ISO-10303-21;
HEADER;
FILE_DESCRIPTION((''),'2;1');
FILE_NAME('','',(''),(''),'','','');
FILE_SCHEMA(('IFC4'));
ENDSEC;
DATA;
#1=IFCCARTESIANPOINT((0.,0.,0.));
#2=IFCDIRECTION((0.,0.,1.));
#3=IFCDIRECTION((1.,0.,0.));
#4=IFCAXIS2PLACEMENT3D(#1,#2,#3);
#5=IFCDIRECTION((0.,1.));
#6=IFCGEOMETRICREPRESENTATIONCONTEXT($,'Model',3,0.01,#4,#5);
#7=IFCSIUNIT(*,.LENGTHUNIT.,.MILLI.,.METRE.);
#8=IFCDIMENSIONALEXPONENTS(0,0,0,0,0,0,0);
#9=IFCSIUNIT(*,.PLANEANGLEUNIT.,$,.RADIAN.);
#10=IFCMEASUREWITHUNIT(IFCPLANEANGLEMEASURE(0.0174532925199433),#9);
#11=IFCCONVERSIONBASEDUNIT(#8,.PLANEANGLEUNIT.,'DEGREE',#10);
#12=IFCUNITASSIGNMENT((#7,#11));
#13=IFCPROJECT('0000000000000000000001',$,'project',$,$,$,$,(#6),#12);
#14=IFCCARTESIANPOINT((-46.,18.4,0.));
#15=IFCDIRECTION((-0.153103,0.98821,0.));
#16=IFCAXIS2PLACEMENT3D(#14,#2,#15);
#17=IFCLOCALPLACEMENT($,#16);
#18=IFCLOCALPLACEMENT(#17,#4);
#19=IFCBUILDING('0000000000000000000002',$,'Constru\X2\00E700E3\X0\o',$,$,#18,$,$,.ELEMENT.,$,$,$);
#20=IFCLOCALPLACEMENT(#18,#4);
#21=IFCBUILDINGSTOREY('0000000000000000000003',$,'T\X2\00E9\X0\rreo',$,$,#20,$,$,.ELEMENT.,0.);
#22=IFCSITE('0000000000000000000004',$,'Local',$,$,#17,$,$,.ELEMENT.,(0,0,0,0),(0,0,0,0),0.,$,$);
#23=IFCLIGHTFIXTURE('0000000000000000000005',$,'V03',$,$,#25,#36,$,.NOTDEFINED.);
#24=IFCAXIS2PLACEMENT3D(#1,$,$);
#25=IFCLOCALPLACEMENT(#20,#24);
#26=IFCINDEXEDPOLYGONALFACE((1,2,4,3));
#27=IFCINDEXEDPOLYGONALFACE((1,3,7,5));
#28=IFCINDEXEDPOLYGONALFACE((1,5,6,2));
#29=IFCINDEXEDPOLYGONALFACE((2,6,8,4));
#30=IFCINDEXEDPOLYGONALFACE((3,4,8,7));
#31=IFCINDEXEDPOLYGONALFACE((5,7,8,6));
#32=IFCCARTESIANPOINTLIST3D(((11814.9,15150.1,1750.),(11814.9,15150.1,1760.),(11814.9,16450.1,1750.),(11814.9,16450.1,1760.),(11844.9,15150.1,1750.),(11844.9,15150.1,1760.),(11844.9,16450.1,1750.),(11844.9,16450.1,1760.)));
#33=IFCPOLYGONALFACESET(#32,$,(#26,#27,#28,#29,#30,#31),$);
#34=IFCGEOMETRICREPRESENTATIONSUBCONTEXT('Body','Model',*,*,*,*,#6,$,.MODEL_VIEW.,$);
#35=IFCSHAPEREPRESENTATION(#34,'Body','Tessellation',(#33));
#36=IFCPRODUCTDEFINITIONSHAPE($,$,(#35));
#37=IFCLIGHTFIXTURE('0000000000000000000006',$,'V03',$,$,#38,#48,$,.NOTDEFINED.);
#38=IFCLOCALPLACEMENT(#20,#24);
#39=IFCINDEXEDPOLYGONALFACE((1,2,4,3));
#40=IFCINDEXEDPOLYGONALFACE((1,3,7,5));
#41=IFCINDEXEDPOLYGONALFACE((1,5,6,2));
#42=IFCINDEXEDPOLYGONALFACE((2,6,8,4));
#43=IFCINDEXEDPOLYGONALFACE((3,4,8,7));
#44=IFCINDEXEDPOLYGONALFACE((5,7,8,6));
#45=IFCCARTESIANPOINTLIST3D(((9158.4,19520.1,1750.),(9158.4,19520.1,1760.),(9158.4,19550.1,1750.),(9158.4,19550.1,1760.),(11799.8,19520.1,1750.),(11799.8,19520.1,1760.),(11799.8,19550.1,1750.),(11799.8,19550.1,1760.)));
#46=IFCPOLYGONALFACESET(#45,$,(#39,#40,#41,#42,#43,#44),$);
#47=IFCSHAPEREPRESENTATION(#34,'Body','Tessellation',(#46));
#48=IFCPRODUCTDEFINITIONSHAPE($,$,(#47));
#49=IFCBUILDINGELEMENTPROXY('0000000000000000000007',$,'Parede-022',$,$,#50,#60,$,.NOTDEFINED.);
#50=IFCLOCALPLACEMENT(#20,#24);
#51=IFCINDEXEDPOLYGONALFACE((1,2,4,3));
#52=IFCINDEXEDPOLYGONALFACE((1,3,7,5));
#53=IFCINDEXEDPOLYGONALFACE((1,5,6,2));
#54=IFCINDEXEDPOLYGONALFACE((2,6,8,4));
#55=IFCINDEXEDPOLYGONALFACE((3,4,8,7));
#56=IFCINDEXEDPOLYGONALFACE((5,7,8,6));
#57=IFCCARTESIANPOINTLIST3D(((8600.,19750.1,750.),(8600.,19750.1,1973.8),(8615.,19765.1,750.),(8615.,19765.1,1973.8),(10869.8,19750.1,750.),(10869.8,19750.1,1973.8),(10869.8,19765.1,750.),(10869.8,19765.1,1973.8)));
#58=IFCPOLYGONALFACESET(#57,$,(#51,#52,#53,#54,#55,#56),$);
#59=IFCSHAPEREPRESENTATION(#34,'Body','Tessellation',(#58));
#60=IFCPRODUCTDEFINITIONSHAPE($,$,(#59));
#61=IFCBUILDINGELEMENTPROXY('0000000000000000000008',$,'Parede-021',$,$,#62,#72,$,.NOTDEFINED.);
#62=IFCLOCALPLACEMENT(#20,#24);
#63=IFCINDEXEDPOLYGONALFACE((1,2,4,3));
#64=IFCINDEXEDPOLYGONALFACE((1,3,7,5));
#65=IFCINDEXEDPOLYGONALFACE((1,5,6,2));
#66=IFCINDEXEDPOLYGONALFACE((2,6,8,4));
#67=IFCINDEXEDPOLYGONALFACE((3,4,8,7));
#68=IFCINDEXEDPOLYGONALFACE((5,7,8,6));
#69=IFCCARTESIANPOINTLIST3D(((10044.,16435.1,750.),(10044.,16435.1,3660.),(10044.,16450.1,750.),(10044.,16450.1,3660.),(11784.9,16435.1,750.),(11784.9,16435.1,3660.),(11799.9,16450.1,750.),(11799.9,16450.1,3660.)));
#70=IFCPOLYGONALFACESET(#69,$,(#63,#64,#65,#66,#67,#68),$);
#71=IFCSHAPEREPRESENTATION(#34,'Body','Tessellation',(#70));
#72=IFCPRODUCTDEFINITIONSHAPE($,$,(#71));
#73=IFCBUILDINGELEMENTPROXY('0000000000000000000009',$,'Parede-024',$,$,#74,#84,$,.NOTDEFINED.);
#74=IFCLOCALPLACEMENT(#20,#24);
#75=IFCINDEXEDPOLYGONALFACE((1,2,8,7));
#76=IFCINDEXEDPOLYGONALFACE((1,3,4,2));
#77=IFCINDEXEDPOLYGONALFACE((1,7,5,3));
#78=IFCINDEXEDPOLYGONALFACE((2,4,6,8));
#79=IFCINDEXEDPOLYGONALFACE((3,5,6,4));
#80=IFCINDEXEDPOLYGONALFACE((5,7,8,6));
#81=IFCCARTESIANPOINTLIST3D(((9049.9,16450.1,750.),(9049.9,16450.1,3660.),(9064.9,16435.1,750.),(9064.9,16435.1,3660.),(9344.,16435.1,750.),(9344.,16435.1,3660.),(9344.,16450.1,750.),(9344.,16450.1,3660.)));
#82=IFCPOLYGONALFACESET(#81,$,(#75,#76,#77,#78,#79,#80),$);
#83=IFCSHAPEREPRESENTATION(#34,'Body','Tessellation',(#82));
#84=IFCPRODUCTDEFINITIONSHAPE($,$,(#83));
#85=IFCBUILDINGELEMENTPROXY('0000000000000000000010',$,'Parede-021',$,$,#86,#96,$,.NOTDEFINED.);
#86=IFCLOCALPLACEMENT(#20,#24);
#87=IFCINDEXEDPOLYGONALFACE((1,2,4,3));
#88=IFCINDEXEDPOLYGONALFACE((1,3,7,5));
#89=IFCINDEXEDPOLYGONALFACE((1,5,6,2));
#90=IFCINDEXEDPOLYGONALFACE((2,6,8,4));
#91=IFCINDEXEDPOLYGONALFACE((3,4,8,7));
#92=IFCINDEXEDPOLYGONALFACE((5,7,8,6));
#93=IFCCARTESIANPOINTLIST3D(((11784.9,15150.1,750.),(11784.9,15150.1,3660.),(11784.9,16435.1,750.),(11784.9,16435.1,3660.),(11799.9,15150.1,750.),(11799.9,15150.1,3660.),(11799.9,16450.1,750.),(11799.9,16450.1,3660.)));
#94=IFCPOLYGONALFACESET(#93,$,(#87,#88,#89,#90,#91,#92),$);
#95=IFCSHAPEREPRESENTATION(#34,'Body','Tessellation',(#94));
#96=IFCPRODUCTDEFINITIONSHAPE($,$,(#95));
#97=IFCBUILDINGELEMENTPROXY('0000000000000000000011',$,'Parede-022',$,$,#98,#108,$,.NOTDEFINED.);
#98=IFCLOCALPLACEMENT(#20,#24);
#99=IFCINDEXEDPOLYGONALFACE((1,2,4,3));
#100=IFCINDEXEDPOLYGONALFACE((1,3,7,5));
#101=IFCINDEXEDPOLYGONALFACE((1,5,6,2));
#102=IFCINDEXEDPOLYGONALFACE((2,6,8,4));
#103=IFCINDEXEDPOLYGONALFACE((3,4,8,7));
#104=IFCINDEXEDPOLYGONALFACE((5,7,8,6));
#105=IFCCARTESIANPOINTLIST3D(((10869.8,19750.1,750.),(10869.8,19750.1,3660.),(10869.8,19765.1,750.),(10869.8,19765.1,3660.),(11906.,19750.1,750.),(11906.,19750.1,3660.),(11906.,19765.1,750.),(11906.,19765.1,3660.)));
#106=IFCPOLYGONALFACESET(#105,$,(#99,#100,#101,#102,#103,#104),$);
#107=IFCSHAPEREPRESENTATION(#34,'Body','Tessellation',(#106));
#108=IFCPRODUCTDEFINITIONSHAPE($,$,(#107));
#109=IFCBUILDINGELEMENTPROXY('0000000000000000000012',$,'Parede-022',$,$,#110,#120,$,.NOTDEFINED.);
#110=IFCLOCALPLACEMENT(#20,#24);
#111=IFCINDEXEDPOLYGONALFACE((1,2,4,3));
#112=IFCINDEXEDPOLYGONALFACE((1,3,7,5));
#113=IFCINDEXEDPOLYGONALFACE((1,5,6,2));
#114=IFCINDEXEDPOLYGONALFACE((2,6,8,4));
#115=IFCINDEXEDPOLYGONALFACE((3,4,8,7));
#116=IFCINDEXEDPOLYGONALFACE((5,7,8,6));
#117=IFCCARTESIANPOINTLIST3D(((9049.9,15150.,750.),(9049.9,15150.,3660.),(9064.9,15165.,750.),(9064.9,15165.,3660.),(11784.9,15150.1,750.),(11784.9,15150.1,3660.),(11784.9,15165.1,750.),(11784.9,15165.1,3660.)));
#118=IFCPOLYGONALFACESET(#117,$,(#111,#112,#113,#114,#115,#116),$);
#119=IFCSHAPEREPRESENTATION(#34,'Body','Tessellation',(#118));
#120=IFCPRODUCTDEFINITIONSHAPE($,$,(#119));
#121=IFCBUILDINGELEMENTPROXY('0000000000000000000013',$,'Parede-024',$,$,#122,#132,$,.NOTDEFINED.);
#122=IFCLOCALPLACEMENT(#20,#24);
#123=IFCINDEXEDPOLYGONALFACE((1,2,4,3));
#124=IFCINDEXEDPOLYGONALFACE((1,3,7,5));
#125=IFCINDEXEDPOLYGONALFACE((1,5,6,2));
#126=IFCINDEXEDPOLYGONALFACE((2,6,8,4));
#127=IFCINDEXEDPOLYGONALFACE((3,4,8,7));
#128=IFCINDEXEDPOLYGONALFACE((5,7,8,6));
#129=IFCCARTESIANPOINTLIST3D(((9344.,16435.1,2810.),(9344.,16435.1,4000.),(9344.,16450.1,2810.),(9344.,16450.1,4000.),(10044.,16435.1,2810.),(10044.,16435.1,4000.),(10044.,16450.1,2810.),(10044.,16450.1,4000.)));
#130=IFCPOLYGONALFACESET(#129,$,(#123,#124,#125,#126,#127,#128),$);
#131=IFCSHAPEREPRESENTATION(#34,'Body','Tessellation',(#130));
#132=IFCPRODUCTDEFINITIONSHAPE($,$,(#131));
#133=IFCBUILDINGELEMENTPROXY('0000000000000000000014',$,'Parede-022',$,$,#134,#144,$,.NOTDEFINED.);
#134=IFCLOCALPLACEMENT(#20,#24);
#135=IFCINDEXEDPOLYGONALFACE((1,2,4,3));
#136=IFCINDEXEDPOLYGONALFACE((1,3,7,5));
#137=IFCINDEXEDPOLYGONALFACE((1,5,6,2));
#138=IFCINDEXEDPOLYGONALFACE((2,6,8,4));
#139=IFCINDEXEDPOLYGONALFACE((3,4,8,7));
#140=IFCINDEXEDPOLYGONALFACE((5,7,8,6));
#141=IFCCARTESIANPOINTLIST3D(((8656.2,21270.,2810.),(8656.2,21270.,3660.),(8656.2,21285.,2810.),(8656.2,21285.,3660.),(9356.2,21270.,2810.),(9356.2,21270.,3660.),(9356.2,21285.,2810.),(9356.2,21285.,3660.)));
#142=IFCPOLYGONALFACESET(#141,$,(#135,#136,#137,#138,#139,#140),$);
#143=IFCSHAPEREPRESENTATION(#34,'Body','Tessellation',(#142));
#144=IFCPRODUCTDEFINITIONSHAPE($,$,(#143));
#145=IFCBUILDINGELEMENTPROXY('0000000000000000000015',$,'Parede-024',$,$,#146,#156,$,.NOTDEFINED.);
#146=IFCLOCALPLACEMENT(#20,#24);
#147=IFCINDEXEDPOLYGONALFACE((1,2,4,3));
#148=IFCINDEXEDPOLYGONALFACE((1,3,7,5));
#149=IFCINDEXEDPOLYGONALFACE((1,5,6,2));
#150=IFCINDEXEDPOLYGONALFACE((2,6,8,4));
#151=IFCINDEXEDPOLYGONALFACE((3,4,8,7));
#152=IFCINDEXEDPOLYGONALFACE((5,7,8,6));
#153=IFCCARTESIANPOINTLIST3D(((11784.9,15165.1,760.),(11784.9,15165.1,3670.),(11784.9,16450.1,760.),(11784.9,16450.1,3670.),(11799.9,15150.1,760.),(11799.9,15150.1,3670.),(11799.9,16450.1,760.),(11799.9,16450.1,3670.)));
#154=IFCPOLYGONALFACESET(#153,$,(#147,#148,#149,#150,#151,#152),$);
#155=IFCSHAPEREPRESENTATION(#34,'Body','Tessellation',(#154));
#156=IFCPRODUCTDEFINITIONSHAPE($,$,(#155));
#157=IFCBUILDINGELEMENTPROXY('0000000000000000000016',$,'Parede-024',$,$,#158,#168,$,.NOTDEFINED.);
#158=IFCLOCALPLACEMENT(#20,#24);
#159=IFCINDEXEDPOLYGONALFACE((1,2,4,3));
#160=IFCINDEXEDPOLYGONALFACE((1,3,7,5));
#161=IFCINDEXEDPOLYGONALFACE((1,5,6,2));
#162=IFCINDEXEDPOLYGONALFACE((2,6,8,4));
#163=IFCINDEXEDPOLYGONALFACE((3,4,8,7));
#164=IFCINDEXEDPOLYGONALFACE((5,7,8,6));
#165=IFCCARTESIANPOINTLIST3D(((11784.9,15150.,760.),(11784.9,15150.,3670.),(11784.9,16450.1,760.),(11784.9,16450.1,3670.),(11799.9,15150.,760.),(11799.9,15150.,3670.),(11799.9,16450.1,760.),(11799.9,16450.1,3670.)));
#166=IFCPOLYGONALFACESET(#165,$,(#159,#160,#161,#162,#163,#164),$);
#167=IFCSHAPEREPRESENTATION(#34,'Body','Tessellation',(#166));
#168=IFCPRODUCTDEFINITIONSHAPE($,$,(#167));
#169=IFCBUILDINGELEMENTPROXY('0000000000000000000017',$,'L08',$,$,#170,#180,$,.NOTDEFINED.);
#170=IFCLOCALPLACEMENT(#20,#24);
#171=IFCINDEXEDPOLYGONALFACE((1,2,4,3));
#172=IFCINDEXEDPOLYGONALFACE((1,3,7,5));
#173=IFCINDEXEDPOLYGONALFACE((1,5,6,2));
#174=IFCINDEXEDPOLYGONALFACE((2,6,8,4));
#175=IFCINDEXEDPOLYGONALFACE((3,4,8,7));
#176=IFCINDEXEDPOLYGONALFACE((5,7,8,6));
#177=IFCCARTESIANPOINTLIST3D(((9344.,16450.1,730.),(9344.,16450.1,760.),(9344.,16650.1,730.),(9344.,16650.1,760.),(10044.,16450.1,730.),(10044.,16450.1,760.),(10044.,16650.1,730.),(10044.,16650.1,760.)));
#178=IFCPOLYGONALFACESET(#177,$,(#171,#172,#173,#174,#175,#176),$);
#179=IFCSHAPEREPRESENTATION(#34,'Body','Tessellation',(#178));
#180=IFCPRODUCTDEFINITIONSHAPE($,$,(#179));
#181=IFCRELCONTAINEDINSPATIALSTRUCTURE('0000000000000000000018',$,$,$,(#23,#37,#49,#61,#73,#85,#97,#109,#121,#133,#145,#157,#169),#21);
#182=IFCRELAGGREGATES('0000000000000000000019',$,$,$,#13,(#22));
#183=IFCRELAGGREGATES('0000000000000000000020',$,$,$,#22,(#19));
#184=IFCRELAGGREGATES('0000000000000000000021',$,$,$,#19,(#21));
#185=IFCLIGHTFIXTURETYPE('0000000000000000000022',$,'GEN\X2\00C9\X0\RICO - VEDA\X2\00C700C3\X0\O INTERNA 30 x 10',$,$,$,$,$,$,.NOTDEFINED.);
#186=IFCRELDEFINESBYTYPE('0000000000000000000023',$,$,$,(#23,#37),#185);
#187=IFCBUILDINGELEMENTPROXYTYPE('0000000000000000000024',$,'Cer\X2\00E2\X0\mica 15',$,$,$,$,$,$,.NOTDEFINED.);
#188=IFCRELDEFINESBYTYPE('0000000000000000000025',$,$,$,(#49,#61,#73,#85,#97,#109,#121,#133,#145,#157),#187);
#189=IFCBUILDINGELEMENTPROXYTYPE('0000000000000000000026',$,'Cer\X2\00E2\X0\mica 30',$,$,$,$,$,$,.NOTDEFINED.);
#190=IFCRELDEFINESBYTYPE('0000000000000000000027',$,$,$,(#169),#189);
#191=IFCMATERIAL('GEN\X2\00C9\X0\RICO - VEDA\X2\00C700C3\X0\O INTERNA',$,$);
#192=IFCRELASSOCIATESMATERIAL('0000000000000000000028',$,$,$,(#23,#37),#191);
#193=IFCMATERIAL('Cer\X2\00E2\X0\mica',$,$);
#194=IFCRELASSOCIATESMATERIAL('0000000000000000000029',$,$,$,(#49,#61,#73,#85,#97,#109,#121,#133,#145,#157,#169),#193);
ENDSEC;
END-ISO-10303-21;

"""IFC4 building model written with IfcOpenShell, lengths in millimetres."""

from ifc_helpers import new_model, entity, si_unit, converted_unit, direction, frame, frame_2d, origin_with_axes, place, context, subcontext, project, spatial, line, indexed_curve, rectangle, outline, extrude, material, type_object, element, save


model = new_model("IFC4")

# Units and contexts
model_context = context("Model", 3, precision=0.01, world=origin_with_axes(), true_north=direction((0.0, 1.0)))
body_context = subcontext(model_context, "Body", "Model", "MODEL_VIEW")
ifc_project = project(units=[si_unit("LENGTHUNIT", "METRE", prefix="MILLI"), converted_unit("PLANEANGLEUNIT", "DEGREE", entity("IfcPlaneAngleMeasure", 0.0174532925199433), si_unit("PLANEANGLEUNIT", "RADIAN"), dimensions=[0, 0, 0, 0, 0, 0, 0])], contexts=[model_context])

# Site, building, storey
site_placement = place(None, frame((-46.0, 18.4, 0.0), z_axis=(0.0, 0.0, 1.0), x_axis=(-0.153103, 0.98821, 0.0)))
site = spatial("IfcSite", under=ifc_project, at=site_placement, Name="Local", CompositionType="ELEMENT", RefLatitude=(0, 0, 0, 0), RefLongitude=(0, 0, 0, 0), RefElevation=0.0)
building_placement = place(site_placement, origin_with_axes())
building = spatial("IfcBuilding", under=site, at=building_placement, Name="Construção", CompositionType="ELEMENT")
storey_placement = place(building_placement, origin_with_axes())
storey = spatial("IfcBuildingStorey", under=building, at=storey_placement, Name="Térreo", CompositionType="ELEMENT", Elevation=0.0)

# Shared definitions
ifc_material_1 = material(Name="GENÉRICO - VEDAÇÃO INTERNA")

# Light fixtures
light_fixture_type = type_object("IfcLightFixtureType", Name="GENÉRICO - VEDAÇÃO INTERNA 30 x 10", PredefinedType="NOTDEFINED")
light_fixture_1_placement = place(storey_placement, frame((11844.9, 15150.1, 1760.0), z_axis=(0.0, 0.0, 1.0), x_axis=(1.0, 0.000019, 0.0)))
element("IfcLightFixture", 1, at=light_fixture_1_placement, inside=storey, type_object=light_fixture_type, material=ifc_material_1, Name="V03", PredefinedType="NOTDEFINED", context=body_context, shape_type="SweptSolid", body=[
    extrude(rectangle(XDim=10.0, YDim=30.0, at=frame_2d((-5.0, -15.0), x_axis=(1.0, 0.0))), frame((0.0, 0.0, 0.0), z_axis=(0.0, 1.0, 0.0), x_axis=(0.0, 0.0, 1.0)), (0.0, 0.0, 1.0), 1300.0),
])
light_fixture_2_placement = place(storey_placement, frame((9158.4, 19520.1, 1760.0), z_axis=(0.0, 0.0, 1.0), x_axis=(0.0, -1.0, 0.0)))
element("IfcLightFixture", 2, at=light_fixture_2_placement, inside=storey, type_object=light_fixture_type, material=ifc_material_1, Name="V03", PredefinedType="NOTDEFINED", context=body_context, shape_type="SweptSolid", body=[
    extrude(rectangle(XDim=10.0, YDim=30.0, at=frame_2d((-5.0, -15.0), x_axis=(1.0, 0.0))), frame((0.0, 0.0, 0.0), z_axis=(0.0, 1.0, 0.0), x_axis=(0.0, 0.0, 1.0)), (0.0, 0.0, 1.0), 2641.4),
])

# Building element proxies
ifc_material_2 = material(Name="Cerâmica")
building_element_proxy_type_1 = type_object("IfcBuildingElementProxyType", Name="Cerâmica 15", PredefinedType="NOTDEFINED")
proxy_1_placement = place(storey_placement, frame((10869.8, 19750.1, 750.0), z_axis=(0.0, 0.0, 1.0), x_axis=(-1.0, 0.0, 0.0)))
element("IfcBuildingElementProxy", 3, at=proxy_1_placement, inside=storey, type_object=building_element_proxy_type_1, material=ifc_material_2, Name="Parede-022", PredefinedType="NOTDEFINED", context=body_context, shape_type="SweptSolid", body=[
    extrude(outline(indexed_curve([(0.0, -15.0), (2254.9, -15.0), (2269.9, 0.0), (0.0, 0.0)], segments=[line(1, 2, 3, 4, 1)])), origin_with_axes(), (0.0, 0.0, 1.0), 1223.8),
])
proxy_2_placement = place(storey_placement, frame((11799.9, 16450.1, 750.0), z_axis=(0.0, 0.0, 1.0), x_axis=(-1.0, 0.0, 0.0)))
element("IfcBuildingElementProxy", 4, at=proxy_2_placement, inside=storey, type_object=building_element_proxy_type_1, material=ifc_material_2, Name="Parede-021", PredefinedType="NOTDEFINED", context=body_context, shape_type="SweptSolid", body=[
    extrude(outline(indexed_curve([(0.0, 0.0), (1755.9, 0.0), (1755.9, 15.0), (15.0, 15.0)], segments=[line(1, 2, 3, 4, 1)])), origin_with_axes(), (0.0, 0.0, 1.0), 2910.0),
])
proxy_3_placement = place(storey_placement, frame((9049.9, 16450.1, 750.0), z_axis=(0.0, 0.0, 1.0), x_axis=(1.0, 0.0, 0.0)))
element("IfcBuildingElementProxy", 5, at=proxy_3_placement, inside=storey, type_object=building_element_proxy_type_1, material=ifc_material_2, Name="Parede-024", PredefinedType="NOTDEFINED", context=body_context, shape_type="SweptSolid", body=[
    extrude(outline(indexed_curve([(15.0, -15.0), (294.0, -15.0), (294.0, 0.0), (0.0, 0.0)], segments=[line(1, 2, 3, 4, 1)])), origin_with_axes(), (0.0, 0.0, 1.0), 2910.0),
])
proxy_4_placement = place(storey_placement, frame((11799.9, 16450.1, 750.0), z_axis=(0.0, 0.0, 1.0), x_axis=(0.000019, -1.0, 0.0)))
element("IfcBuildingElementProxy", 6, at=proxy_4_placement, inside=storey, type_object=building_element_proxy_type_1, material=ifc_material_2, Name="Parede-021", PredefinedType="NOTDEFINED", context=body_context, shape_type="SweptSolid", body=[
    extrude(outline(indexed_curve([(15.0, -15.0), (1300.0, -15.0), (1300.0, 0.0), (0.0, 0.0)], segments=[line(1, 2, 3, 4, 1)])), origin_with_axes(), (0.0, 0.0, 1.0), 2910.0),
])
proxy_5_placement = place(storey_placement, frame((11906.0, 19750.1, 750.0), z_axis=(0.0, 0.0, 1.0), x_axis=(-1.0, 0.0, 0.0)))
element("IfcBuildingElementProxy", 7, at=proxy_5_placement, inside=storey, type_object=building_element_proxy_type_1, material=ifc_material_2, Name="Parede-022", PredefinedType="NOTDEFINED", context=body_context, shape_type="SweptSolid", body=[
    extrude(outline(indexed_curve([(0.0, -15.0), (1036.2, -15.0), (1036.2, 0.0), (0.0, 0.0)], segments=[line(1, 2, 3, 4, 1)])), origin_with_axes(), (0.0, 0.0, 1.0), 2910.0),
])
proxy_6_placement = place(storey_placement, frame((11799.9, 15150.1, 750.0), z_axis=(0.0, 0.0, 1.0), x_axis=(-1.0, -0.000036, 0.0)))
element("IfcBuildingElementProxy", 8, at=proxy_6_placement, inside=storey, type_object=building_element_proxy_type_1, material=ifc_material_2, Name="Parede-022", PredefinedType="NOTDEFINED", context=body_context, shape_type="SweptSolid", body=[
    extrude(outline(indexed_curve([(15.0, -15.0), (2734.9, -15.0), (2750.0, 0.0), (15.0, 0.0)], segments=[line(1, 2, 3, 4, 1)])), origin_with_axes(), (0.0, 0.0, 1.0), 2910.0),
])
proxy_7_placement = place(storey_placement, frame((9344.0, 16450.1, 2810.0), z_axis=(0.0, 0.0, 1.0), x_axis=(1.0, 0.0, 0.0)))
element("IfcBuildingElementProxy", 9, at=proxy_7_placement, inside=storey, type_object=building_element_proxy_type_1, material=ifc_material_2, Name="Parede-024", PredefinedType="NOTDEFINED", context=body_context, shape_type="SweptSolid", body=[
    extrude(outline(indexed_curve([(0.0, -15.0), (700.0, -15.0), (700.0, 0.0), (0.0, 0.0)], segments=[line(1, 2, 3, 4, 1)])), origin_with_axes(), (0.0, 0.0, 1.0), 1190.0),
])
proxy_8_placement = place(storey_placement, frame((9356.2, 21285.0, 2810.0), z_axis=(0.0, 0.0, 1.0), x_axis=(-1.0, 0.0, 0.0)))
element("IfcBuildingElementProxy", 10, at=proxy_8_placement, inside=storey, type_object=building_element_proxy_type_1, material=ifc_material_2, Name="Parede-022", PredefinedType="NOTDEFINED", context=body_context, shape_type="SweptSolid", body=[
    extrude(outline(indexed_curve([(0.0, 0.0), (700.0, 0.0), (700.0, 15.0), (0.0, 15.0)], segments=[line(1, 2, 3, 4, 1)])), origin_with_axes(), (0.0, 0.0, 1.0), 850.0),
])
proxy_9_placement = place(storey_placement, frame((11799.9, 15150.1, 760.0), z_axis=(0.0, 0.0, 1.0), x_axis=(0.0, 1.0, 0.0)))
element("IfcBuildingElementProxy", 11, at=proxy_9_placement, inside=storey, type_object=building_element_proxy_type_1, material=ifc_material_2, Name="Parede-024", PredefinedType="NOTDEFINED", context=body_context, shape_type="SweptSolid", body=[
    extrude(outline(indexed_curve([(0.0, 0.0), (1300.0, 0.0), (1300.0, 15.0), (15.0, 15.0)], segments=[line(1, 2, 3, 4, 1)])), origin_with_axes(), (0.0, 0.0, 1.0), 2910.0),
])
proxy_10_placement = place(storey_placement, frame((11799.9, 15150.0, 760.0), z_axis=(0.0, 0.0, 1.0), x_axis=(0.0, 1.0, 0.0)))
element("IfcBuildingElementProxy", 12, at=proxy_10_placement, inside=storey, type_object=building_element_proxy_type_1, material=ifc_material_2, Name="Parede-024", PredefinedType="NOTDEFINED", context=body_context, shape_type="SweptSolid", body=[
    extrude(outline(indexed_curve([(0.0, 0.0), (1300.0, 0.0), (1300.0, 15.0), (0.0, 15.0)], segments=[line(1, 2, 3, 4, 1)])), origin_with_axes(), (0.0, 0.0, 1.0), 2910.0),
])
building_element_proxy_type_2 = type_object("IfcBuildingElementProxyType", Name="Cerâmica 30", PredefinedType="NOTDEFINED")
proxy_11_placement = place(storey_placement, frame((9344.0, 16450.1, 760.0), z_axis=(0.0, 0.0, 1.0), x_axis=(1.0, 0.0, 0.0)))
element("IfcBuildingElementProxy", 13, at=proxy_11_placement, inside=storey, type_object=building_element_proxy_type_2, material=ifc_material_2, Name="L08", PredefinedType="NOTDEFINED", context=body_context, shape_type="SweptSolid", body=[
    extrude(outline(indexed_curve([(0.0, 0.0), (700.0, 0.0), (700.0, 200.0), (0.0, 200.0)], segments=[line(1, 2, 3, 4, 1)])), frame((0.0, 0.0, -30.0), z_axis=(0.0, 0.0, 1.0), x_axis=(1.0, 0.0, 0.0)), (0.0, 0.0, 1.0), 30.0),
])

save(model, "model.ifc")
